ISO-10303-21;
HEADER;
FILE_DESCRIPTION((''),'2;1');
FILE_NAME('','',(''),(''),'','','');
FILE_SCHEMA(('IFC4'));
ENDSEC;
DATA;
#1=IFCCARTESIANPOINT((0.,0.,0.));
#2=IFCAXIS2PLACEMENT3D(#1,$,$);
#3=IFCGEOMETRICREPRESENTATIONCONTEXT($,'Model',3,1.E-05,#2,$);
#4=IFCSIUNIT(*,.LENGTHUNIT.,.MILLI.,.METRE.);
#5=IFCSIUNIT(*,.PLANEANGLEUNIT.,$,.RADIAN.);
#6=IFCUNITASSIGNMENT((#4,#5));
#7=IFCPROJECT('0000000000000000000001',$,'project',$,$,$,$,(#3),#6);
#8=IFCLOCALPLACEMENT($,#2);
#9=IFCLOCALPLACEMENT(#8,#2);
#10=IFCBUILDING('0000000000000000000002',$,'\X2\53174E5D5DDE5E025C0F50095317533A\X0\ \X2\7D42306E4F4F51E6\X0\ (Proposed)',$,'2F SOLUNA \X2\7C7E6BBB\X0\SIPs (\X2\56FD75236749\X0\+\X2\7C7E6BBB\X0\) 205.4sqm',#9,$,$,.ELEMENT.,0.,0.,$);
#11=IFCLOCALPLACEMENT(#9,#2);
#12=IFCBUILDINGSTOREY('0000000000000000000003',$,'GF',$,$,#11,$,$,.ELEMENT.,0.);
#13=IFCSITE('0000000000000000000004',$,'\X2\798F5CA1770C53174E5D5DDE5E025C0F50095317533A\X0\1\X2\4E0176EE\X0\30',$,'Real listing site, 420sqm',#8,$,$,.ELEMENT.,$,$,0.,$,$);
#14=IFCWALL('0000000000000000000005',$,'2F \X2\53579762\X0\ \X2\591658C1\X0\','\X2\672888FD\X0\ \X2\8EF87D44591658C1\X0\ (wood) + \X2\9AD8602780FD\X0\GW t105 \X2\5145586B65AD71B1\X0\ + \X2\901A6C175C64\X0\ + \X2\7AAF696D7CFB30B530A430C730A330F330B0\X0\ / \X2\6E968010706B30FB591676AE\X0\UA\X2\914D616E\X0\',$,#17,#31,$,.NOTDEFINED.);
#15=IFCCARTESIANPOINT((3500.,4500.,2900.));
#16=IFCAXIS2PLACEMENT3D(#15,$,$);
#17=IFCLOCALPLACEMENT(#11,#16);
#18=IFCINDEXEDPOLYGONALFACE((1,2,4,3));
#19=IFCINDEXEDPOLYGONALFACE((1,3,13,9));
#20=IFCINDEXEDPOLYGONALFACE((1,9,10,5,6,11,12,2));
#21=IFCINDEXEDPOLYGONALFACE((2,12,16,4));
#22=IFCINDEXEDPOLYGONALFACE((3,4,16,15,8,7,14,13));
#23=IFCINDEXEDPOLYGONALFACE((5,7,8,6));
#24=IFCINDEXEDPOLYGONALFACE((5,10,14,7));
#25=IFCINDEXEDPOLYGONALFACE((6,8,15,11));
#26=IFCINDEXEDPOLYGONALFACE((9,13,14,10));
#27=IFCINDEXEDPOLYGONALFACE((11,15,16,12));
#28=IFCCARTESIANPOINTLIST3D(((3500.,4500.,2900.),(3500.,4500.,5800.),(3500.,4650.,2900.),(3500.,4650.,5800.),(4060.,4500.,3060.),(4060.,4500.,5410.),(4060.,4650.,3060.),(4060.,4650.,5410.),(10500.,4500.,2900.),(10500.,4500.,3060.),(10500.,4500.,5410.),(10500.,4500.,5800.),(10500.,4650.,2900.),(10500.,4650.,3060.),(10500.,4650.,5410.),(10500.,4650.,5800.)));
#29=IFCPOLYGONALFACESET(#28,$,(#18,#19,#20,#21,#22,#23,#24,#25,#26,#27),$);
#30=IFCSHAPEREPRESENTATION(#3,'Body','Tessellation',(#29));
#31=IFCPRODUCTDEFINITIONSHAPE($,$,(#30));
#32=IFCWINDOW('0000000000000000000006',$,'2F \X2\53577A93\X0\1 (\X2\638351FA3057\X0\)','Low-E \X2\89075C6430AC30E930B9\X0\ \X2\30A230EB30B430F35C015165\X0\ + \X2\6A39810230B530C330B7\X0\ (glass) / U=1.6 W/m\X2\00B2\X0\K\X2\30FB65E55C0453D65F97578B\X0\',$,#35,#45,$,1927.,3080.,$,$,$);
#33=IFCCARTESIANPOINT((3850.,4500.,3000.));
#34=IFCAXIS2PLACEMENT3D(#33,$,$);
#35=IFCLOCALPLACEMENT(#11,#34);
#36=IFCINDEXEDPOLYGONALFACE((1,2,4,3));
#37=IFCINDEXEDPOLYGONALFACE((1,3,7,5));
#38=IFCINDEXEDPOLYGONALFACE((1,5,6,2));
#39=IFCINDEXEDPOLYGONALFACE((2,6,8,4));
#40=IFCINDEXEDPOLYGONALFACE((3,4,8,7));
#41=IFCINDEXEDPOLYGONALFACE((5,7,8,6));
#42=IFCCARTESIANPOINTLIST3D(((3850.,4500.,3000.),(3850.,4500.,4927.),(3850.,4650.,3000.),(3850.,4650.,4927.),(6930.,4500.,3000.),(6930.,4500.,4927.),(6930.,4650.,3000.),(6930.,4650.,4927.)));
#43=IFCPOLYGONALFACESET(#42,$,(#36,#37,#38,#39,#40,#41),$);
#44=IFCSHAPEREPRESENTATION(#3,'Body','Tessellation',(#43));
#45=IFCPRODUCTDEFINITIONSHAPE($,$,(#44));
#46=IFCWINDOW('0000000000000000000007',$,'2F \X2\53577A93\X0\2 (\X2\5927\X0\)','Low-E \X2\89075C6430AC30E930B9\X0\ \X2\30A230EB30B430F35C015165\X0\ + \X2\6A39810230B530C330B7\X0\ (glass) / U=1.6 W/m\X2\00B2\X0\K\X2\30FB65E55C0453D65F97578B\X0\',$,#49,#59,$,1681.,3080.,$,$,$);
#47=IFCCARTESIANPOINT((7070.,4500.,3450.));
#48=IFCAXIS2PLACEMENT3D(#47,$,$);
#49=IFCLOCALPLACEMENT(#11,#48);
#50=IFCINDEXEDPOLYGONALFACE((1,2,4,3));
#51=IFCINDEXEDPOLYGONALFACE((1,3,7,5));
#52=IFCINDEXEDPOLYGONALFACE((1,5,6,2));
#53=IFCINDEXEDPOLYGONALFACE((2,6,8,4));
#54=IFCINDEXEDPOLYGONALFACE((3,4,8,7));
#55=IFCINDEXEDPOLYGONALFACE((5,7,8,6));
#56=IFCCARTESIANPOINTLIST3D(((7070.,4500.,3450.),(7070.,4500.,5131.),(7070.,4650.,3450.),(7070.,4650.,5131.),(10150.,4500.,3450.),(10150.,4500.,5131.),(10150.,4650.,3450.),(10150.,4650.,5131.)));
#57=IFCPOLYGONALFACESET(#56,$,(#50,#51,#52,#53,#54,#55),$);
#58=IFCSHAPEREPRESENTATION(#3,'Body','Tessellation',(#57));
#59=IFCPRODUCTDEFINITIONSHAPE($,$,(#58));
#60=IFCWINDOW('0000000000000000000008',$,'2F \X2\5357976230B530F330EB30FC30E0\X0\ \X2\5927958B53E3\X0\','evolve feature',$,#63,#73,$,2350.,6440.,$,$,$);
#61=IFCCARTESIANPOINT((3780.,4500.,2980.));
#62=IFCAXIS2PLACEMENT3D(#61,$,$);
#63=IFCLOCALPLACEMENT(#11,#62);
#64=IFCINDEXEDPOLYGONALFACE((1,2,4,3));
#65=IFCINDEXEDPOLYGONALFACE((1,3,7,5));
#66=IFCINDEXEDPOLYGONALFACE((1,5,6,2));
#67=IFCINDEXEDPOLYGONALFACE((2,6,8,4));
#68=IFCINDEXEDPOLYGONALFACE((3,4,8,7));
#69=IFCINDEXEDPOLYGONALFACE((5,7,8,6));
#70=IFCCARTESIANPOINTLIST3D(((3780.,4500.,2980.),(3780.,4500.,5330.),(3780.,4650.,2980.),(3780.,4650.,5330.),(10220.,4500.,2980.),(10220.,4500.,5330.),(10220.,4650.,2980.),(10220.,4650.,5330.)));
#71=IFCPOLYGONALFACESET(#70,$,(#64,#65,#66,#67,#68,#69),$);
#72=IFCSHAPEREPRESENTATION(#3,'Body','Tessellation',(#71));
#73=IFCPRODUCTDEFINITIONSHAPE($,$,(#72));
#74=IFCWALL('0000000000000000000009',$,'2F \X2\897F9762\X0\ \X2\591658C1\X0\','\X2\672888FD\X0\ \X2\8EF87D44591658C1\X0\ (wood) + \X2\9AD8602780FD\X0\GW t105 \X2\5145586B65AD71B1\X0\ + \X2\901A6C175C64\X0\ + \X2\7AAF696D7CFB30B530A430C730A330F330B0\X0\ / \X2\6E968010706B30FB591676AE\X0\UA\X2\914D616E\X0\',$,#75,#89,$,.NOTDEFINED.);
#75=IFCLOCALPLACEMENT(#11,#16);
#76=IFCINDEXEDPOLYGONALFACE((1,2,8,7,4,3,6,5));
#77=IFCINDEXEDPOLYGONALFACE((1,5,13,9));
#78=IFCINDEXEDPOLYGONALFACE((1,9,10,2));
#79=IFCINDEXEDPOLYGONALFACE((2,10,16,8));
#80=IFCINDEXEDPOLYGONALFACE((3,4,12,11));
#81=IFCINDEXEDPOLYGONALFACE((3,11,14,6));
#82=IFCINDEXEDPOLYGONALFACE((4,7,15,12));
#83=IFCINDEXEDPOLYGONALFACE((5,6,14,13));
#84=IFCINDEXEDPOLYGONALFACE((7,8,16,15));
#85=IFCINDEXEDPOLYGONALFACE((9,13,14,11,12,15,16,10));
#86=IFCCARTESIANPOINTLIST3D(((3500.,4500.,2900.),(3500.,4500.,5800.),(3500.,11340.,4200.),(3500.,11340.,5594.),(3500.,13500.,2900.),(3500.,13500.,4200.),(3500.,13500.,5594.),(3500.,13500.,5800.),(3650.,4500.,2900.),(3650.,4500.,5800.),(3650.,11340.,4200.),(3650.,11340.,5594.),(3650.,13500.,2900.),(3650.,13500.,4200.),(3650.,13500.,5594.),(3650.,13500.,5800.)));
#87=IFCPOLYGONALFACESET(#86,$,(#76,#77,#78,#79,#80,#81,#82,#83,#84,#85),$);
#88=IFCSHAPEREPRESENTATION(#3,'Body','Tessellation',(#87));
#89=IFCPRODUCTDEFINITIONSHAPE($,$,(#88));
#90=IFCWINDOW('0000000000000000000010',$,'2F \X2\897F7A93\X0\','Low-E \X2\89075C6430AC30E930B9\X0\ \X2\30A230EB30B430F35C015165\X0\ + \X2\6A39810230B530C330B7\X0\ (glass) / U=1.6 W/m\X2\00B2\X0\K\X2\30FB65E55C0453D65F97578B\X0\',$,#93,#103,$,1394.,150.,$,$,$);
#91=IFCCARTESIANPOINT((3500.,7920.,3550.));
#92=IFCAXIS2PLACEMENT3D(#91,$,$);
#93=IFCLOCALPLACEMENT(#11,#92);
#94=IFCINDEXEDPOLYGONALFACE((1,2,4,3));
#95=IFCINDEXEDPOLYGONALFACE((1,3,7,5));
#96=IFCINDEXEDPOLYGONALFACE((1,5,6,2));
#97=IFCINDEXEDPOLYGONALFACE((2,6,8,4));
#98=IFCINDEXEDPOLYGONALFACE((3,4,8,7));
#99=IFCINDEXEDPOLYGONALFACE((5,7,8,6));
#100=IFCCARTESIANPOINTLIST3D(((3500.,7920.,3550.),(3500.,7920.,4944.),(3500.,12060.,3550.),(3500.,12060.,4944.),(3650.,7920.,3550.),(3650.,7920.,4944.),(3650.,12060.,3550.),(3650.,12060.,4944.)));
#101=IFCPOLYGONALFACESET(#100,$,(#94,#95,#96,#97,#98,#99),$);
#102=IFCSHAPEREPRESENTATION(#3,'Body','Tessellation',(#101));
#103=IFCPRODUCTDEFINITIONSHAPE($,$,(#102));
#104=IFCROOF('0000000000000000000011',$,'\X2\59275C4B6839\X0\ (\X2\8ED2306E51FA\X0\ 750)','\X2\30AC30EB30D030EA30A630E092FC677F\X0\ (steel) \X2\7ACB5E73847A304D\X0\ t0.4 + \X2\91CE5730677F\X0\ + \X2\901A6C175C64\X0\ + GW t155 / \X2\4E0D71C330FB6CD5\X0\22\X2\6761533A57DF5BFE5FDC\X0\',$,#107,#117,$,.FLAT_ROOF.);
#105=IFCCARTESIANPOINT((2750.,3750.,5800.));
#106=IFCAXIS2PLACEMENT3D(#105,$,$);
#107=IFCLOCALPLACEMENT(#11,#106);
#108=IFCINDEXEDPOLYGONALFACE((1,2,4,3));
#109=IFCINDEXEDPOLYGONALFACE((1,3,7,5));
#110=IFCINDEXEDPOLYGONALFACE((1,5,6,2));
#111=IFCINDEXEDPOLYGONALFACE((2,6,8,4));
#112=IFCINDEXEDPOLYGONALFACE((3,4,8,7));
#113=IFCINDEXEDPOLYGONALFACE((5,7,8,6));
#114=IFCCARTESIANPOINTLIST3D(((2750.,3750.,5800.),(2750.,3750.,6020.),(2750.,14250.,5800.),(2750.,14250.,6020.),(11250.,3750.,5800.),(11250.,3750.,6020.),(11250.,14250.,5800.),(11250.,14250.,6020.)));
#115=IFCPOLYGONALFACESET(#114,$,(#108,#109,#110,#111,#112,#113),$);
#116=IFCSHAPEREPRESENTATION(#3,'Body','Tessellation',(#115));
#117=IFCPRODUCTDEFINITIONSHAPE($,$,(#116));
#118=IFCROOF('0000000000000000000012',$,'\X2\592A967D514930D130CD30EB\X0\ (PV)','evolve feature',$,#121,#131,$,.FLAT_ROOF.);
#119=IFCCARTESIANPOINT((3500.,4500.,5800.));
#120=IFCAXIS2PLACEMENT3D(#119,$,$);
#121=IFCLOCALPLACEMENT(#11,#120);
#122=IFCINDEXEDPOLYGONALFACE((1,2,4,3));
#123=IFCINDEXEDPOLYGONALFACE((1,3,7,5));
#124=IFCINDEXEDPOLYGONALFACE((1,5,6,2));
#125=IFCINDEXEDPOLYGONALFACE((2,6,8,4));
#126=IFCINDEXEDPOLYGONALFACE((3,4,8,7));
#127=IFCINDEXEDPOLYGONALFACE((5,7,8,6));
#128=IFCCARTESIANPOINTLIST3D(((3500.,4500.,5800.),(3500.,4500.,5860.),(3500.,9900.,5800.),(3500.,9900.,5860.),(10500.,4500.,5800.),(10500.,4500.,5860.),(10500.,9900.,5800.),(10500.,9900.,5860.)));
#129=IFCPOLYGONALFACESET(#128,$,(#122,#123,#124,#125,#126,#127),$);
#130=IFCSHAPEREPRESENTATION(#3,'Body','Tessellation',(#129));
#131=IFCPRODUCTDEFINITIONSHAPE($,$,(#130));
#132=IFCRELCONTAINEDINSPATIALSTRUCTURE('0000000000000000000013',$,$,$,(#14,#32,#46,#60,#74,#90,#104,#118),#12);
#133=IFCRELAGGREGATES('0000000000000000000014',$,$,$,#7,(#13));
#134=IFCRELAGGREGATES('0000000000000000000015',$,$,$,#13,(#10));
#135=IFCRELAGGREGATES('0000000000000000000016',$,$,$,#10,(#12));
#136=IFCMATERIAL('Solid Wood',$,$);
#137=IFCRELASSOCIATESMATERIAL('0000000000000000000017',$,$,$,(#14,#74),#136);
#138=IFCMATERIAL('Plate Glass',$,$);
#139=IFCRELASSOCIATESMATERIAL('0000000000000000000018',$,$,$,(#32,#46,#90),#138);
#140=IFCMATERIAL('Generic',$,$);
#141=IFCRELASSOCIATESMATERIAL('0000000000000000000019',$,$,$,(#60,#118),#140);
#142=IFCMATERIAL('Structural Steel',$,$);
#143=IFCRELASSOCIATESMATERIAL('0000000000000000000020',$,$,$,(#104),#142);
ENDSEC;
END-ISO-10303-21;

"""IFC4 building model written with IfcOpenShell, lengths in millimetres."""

from ifc_helpers import new_model, si_unit, frame, frame_2d, origin, place, context, project, spatial, rectangle, extrude, material, element, fill, save


model = new_model("IFC4")

# Units and contexts
model_context = context("Model", 3, precision=1e-05, world=origin())
ifc_project = project(units=[si_unit("LENGTHUNIT", "METRE", prefix="MILLI"), si_unit("PLANEANGLEUNIT", "RADIAN")], contexts=[model_context])

# Site, building, storey
site_placement = place(None, origin())
site = spatial("IfcSite", under=ifc_project, at=site_placement, Name="福岡県北九州市小倉北区1丁目30", ObjectType="Real listing site, 420sqm", CompositionType="ELEMENT", RefElevation=0.0)
building_placement = place(site_placement, origin())
building = spatial("IfcBuilding", under=site, at=building_placement, Name="北九州市小倉北区 終の住処 (Proposed)", ObjectType="2F SOLUNA 籾殻SIPs (国産杉+籾殻) 205.4sqm", CompositionType="ELEMENT", ElevationOfRefHeight=0.0, ElevationOfTerrain=0.0)
storey_placement = place(building_placement, origin())
storey = spatial("IfcBuildingStorey", under=building, at=storey_placement, Name="GF", CompositionType="ELEMENT", Elevation=0.0)

# Shared definitions
ifc_material_1 = material(Name="Solid Wood")
ifc_material_2 = material(Name="Generic")

# Shared definitions
ifc_material_3 = material(Name="Plate Glass")

# Wall, openings, windows
wall_1_placement = place(storey_placement, frame((3500.0, 4500.0, 2900.0)))
wall_1 = element("IfcWall", 1, at=wall_1_placement, inside=storey, material=ifc_material_1, Name="2F 南面 外壁", Description="木製 軸組外壁 (wood) + 高性能GW t105 充填断熱 + 通気層 + 窯業系サイディング / 準耐火・外皮UA配慮", PredefinedType="NOTDEFINED", context=model_context, shape_type="SweptSolid", body=[
    extrude(rectangle(XDim=7000.0, YDim=150.0, at=frame_2d((3500.0, 75.0))), frame((3500.0, 4500.0, 2900.0)), (0.0, 0.0, 1.0), 2900.0),
])
opening_1_placement = place(storey_placement, frame((3850.0, 4500.0, 3000.0)))
opening_1 = element("IfcOpeningElement", 2, at=opening_1_placement, cuts=wall_1, PredefinedType="NOTDEFINED", context=model_context, shape_type="SweptSolid", body=[
    extrude(rectangle(XDim=3080.0, YDim=150.0, at=frame_2d((1540.0, 75.0))), frame((3850.0, 4500.0, 3000.0)), (0.0, 0.0, 1.0), 1927.0),
])
opening_2_placement = place(storey_placement, frame((7070.0, 4500.0, 3450.0)))
opening_2 = element("IfcOpeningElement", 3, at=opening_2_placement, cuts=wall_1, PredefinedType="NOTDEFINED", context=model_context, shape_type="SweptSolid", body=[
    extrude(rectangle(XDim=3080.0, YDim=150.0, at=frame_2d((1540.0, 75.0))), frame((7070.0, 4500.0, 3450.0)), (0.0, 0.0, 1.0), 1681.0),
])
opening_3_placement = place(storey_placement, frame((3780.0, 4500.0, 2980.0)))
opening_3 = element("IfcOpeningElement", 4, at=opening_3_placement, cuts=wall_1, PredefinedType="NOTDEFINED", context=model_context, shape_type="SweptSolid", body=[
    extrude(rectangle(XDim=6440.0, YDim=150.0, at=frame_2d((3220.0, 75.0))), frame((3780.0, 4500.0, 2980.0)), (0.0, 0.0, 1.0), 2350.0),
])
window_1_placement = place(storey_placement, frame((3850.0, 4500.0, 3000.0)))
window_1 = element("IfcWindow", 5, at=window_1_placement, inside=storey, material=ifc_material_3, Name="2F 南窓1 (掃出し)", Description="Low-E 複層ガラス アルゴン封入 + 樹脂サッシ (glass) / U=1.6 W/m²K・日射取得型", OverallHeight=1927.0, OverallWidth=3080.0, context=model_context, shape_type="SweptSolid", body=[
    extrude(rectangle(XDim=3080.0, YDim=150.0, at=frame_2d((1540.0, 75.0))), frame((3850.0, 4500.0, 3000.0)), (0.0, 0.0, 1.0), 1927.0),
])
fill(opening_1, window_1)
window_2_placement = place(storey_placement, frame((7070.0, 4500.0, 3450.0)))
window_2 = element("IfcWindow", 6, at=window_2_placement, inside=storey, material=ifc_material_3, Name="2F 南窓2 (大)", Description="Low-E 複層ガラス アルゴン封入 + 樹脂サッシ (glass) / U=1.6 W/m²K・日射取得型", OverallHeight=1681.0, OverallWidth=3080.0, context=model_context, shape_type="SweptSolid", body=[
    extrude(rectangle(XDim=3080.0, YDim=150.0, at=frame_2d((1540.0, 75.0))), frame((7070.0, 4500.0, 3450.0)), (0.0, 0.0, 1.0), 1681.0),
])
fill(opening_2, window_2)
window_3_placement = place(storey_placement, frame((3780.0, 4500.0, 2980.0)))
window_3 = element("IfcWindow", 7, at=window_3_placement, inside=storey, material=ifc_material_2, Name="2F 南面サンルーム 大開口", Description="evolve feature", OverallHeight=2350.0, OverallWidth=6440.0, context=model_context, shape_type="SweptSolid", body=[
    extrude(rectangle(XDim=6440.0, YDim=150.0, at=frame_2d((3220.0, 75.0))), frame((3780.0, 4500.0, 2980.0)), (0.0, 0.0, 1.0), 2350.0),
])
fill(opening_3, window_3)

# Wall, opening, window
wall_2_placement = place(storey_placement, frame((3500.0, 4500.0, 2900.0)))
wall_2 = element("IfcWall", 8, at=wall_2_placement, inside=storey, material=ifc_material_1, Name="2F 西面 外壁", Description="木製 軸組外壁 (wood) + 高性能GW t105 充填断熱 + 通気層 + 窯業系サイディング / 準耐火・外皮UA配慮", PredefinedType="NOTDEFINED", context=model_context, shape_type="SweptSolid", body=[
    extrude(rectangle(XDim=150.0, YDim=9000.0, at=frame_2d((75.0, 4500.0))), frame((3500.0, 4500.0, 2900.0)), (0.0, 0.0, 1.0), 2900.0),
])
opening_4_placement = place(storey_placement, frame((3500.0, 7920.0, 3550.0)))
opening_4 = element("IfcOpeningElement", 9, at=opening_4_placement, cuts=wall_2, PredefinedType="NOTDEFINED", context=model_context, shape_type="SweptSolid", body=[
    extrude(rectangle(XDim=150.0, YDim=4140.0, at=frame_2d((75.0, 2070.0))), frame((3500.0, 7920.0, 3550.0)), (0.0, 0.0, 1.0), 1394.0),
])
window_4_placement = place(storey_placement, frame((3500.0, 7920.0, 3550.0)))
window_4 = element("IfcWindow", 10, at=window_4_placement, inside=storey, material=ifc_material_3, Name="2F 西窓", Description="Low-E 複層ガラス アルゴン封入 + 樹脂サッシ (glass) / U=1.6 W/m²K・日射取得型", OverallHeight=1394.0, OverallWidth=150.0, context=model_context, shape_type="SweptSolid", body=[
    extrude(rectangle(XDim=150.0, YDim=4140.0, at=frame_2d((75.0, 2070.0))), frame((3500.0, 7920.0, 3550.0)), (0.0, 0.0, 1.0), 1394.0),
])
fill(opening_4, window_4)

# Roofs
ifc_material_4 = material(Name="Structural Steel")
roof_1_placement = place(storey_placement, frame((2750.0, 3750.0, 5800.0)))
element("IfcRoof", 11, at=roof_1_placement, inside=storey, material=ifc_material_4, Name="大屋根 (軒の出 750)", Description="ガルバリウム鋼板 (steel) 立平葺き t0.4 + 野地板 + 通気層 + GW t155 / 不燃・法22条区域対応", PredefinedType="FLAT_ROOF", context=model_context, shape_type="SweptSolid", body=[
    extrude(rectangle(XDim=8500.0, YDim=10500.0, at=frame_2d((4250.0, 5250.0))), frame((2750.0, 3750.0, 5800.0)), (0.0, 0.0, 1.0), 220.0),
])
roof_2_placement = place(storey_placement, frame((3500.0, 4500.0, 5800.0)))
element("IfcRoof", 12, at=roof_2_placement, inside=storey, material=ifc_material_2, Name="太陽光パネル (PV)", Description="evolve feature", PredefinedType="FLAT_ROOF", context=model_context, shape_type="SweptSolid", body=[
    extrude(rectangle(XDim=7000.0, YDim=5400.0, at=frame_2d((3500.0, 2700.0))), frame((3500.0, 4500.0, 5800.0)), (0.0, 0.0, 1.0), 60.0),
])

save(model, "model.ifc")
